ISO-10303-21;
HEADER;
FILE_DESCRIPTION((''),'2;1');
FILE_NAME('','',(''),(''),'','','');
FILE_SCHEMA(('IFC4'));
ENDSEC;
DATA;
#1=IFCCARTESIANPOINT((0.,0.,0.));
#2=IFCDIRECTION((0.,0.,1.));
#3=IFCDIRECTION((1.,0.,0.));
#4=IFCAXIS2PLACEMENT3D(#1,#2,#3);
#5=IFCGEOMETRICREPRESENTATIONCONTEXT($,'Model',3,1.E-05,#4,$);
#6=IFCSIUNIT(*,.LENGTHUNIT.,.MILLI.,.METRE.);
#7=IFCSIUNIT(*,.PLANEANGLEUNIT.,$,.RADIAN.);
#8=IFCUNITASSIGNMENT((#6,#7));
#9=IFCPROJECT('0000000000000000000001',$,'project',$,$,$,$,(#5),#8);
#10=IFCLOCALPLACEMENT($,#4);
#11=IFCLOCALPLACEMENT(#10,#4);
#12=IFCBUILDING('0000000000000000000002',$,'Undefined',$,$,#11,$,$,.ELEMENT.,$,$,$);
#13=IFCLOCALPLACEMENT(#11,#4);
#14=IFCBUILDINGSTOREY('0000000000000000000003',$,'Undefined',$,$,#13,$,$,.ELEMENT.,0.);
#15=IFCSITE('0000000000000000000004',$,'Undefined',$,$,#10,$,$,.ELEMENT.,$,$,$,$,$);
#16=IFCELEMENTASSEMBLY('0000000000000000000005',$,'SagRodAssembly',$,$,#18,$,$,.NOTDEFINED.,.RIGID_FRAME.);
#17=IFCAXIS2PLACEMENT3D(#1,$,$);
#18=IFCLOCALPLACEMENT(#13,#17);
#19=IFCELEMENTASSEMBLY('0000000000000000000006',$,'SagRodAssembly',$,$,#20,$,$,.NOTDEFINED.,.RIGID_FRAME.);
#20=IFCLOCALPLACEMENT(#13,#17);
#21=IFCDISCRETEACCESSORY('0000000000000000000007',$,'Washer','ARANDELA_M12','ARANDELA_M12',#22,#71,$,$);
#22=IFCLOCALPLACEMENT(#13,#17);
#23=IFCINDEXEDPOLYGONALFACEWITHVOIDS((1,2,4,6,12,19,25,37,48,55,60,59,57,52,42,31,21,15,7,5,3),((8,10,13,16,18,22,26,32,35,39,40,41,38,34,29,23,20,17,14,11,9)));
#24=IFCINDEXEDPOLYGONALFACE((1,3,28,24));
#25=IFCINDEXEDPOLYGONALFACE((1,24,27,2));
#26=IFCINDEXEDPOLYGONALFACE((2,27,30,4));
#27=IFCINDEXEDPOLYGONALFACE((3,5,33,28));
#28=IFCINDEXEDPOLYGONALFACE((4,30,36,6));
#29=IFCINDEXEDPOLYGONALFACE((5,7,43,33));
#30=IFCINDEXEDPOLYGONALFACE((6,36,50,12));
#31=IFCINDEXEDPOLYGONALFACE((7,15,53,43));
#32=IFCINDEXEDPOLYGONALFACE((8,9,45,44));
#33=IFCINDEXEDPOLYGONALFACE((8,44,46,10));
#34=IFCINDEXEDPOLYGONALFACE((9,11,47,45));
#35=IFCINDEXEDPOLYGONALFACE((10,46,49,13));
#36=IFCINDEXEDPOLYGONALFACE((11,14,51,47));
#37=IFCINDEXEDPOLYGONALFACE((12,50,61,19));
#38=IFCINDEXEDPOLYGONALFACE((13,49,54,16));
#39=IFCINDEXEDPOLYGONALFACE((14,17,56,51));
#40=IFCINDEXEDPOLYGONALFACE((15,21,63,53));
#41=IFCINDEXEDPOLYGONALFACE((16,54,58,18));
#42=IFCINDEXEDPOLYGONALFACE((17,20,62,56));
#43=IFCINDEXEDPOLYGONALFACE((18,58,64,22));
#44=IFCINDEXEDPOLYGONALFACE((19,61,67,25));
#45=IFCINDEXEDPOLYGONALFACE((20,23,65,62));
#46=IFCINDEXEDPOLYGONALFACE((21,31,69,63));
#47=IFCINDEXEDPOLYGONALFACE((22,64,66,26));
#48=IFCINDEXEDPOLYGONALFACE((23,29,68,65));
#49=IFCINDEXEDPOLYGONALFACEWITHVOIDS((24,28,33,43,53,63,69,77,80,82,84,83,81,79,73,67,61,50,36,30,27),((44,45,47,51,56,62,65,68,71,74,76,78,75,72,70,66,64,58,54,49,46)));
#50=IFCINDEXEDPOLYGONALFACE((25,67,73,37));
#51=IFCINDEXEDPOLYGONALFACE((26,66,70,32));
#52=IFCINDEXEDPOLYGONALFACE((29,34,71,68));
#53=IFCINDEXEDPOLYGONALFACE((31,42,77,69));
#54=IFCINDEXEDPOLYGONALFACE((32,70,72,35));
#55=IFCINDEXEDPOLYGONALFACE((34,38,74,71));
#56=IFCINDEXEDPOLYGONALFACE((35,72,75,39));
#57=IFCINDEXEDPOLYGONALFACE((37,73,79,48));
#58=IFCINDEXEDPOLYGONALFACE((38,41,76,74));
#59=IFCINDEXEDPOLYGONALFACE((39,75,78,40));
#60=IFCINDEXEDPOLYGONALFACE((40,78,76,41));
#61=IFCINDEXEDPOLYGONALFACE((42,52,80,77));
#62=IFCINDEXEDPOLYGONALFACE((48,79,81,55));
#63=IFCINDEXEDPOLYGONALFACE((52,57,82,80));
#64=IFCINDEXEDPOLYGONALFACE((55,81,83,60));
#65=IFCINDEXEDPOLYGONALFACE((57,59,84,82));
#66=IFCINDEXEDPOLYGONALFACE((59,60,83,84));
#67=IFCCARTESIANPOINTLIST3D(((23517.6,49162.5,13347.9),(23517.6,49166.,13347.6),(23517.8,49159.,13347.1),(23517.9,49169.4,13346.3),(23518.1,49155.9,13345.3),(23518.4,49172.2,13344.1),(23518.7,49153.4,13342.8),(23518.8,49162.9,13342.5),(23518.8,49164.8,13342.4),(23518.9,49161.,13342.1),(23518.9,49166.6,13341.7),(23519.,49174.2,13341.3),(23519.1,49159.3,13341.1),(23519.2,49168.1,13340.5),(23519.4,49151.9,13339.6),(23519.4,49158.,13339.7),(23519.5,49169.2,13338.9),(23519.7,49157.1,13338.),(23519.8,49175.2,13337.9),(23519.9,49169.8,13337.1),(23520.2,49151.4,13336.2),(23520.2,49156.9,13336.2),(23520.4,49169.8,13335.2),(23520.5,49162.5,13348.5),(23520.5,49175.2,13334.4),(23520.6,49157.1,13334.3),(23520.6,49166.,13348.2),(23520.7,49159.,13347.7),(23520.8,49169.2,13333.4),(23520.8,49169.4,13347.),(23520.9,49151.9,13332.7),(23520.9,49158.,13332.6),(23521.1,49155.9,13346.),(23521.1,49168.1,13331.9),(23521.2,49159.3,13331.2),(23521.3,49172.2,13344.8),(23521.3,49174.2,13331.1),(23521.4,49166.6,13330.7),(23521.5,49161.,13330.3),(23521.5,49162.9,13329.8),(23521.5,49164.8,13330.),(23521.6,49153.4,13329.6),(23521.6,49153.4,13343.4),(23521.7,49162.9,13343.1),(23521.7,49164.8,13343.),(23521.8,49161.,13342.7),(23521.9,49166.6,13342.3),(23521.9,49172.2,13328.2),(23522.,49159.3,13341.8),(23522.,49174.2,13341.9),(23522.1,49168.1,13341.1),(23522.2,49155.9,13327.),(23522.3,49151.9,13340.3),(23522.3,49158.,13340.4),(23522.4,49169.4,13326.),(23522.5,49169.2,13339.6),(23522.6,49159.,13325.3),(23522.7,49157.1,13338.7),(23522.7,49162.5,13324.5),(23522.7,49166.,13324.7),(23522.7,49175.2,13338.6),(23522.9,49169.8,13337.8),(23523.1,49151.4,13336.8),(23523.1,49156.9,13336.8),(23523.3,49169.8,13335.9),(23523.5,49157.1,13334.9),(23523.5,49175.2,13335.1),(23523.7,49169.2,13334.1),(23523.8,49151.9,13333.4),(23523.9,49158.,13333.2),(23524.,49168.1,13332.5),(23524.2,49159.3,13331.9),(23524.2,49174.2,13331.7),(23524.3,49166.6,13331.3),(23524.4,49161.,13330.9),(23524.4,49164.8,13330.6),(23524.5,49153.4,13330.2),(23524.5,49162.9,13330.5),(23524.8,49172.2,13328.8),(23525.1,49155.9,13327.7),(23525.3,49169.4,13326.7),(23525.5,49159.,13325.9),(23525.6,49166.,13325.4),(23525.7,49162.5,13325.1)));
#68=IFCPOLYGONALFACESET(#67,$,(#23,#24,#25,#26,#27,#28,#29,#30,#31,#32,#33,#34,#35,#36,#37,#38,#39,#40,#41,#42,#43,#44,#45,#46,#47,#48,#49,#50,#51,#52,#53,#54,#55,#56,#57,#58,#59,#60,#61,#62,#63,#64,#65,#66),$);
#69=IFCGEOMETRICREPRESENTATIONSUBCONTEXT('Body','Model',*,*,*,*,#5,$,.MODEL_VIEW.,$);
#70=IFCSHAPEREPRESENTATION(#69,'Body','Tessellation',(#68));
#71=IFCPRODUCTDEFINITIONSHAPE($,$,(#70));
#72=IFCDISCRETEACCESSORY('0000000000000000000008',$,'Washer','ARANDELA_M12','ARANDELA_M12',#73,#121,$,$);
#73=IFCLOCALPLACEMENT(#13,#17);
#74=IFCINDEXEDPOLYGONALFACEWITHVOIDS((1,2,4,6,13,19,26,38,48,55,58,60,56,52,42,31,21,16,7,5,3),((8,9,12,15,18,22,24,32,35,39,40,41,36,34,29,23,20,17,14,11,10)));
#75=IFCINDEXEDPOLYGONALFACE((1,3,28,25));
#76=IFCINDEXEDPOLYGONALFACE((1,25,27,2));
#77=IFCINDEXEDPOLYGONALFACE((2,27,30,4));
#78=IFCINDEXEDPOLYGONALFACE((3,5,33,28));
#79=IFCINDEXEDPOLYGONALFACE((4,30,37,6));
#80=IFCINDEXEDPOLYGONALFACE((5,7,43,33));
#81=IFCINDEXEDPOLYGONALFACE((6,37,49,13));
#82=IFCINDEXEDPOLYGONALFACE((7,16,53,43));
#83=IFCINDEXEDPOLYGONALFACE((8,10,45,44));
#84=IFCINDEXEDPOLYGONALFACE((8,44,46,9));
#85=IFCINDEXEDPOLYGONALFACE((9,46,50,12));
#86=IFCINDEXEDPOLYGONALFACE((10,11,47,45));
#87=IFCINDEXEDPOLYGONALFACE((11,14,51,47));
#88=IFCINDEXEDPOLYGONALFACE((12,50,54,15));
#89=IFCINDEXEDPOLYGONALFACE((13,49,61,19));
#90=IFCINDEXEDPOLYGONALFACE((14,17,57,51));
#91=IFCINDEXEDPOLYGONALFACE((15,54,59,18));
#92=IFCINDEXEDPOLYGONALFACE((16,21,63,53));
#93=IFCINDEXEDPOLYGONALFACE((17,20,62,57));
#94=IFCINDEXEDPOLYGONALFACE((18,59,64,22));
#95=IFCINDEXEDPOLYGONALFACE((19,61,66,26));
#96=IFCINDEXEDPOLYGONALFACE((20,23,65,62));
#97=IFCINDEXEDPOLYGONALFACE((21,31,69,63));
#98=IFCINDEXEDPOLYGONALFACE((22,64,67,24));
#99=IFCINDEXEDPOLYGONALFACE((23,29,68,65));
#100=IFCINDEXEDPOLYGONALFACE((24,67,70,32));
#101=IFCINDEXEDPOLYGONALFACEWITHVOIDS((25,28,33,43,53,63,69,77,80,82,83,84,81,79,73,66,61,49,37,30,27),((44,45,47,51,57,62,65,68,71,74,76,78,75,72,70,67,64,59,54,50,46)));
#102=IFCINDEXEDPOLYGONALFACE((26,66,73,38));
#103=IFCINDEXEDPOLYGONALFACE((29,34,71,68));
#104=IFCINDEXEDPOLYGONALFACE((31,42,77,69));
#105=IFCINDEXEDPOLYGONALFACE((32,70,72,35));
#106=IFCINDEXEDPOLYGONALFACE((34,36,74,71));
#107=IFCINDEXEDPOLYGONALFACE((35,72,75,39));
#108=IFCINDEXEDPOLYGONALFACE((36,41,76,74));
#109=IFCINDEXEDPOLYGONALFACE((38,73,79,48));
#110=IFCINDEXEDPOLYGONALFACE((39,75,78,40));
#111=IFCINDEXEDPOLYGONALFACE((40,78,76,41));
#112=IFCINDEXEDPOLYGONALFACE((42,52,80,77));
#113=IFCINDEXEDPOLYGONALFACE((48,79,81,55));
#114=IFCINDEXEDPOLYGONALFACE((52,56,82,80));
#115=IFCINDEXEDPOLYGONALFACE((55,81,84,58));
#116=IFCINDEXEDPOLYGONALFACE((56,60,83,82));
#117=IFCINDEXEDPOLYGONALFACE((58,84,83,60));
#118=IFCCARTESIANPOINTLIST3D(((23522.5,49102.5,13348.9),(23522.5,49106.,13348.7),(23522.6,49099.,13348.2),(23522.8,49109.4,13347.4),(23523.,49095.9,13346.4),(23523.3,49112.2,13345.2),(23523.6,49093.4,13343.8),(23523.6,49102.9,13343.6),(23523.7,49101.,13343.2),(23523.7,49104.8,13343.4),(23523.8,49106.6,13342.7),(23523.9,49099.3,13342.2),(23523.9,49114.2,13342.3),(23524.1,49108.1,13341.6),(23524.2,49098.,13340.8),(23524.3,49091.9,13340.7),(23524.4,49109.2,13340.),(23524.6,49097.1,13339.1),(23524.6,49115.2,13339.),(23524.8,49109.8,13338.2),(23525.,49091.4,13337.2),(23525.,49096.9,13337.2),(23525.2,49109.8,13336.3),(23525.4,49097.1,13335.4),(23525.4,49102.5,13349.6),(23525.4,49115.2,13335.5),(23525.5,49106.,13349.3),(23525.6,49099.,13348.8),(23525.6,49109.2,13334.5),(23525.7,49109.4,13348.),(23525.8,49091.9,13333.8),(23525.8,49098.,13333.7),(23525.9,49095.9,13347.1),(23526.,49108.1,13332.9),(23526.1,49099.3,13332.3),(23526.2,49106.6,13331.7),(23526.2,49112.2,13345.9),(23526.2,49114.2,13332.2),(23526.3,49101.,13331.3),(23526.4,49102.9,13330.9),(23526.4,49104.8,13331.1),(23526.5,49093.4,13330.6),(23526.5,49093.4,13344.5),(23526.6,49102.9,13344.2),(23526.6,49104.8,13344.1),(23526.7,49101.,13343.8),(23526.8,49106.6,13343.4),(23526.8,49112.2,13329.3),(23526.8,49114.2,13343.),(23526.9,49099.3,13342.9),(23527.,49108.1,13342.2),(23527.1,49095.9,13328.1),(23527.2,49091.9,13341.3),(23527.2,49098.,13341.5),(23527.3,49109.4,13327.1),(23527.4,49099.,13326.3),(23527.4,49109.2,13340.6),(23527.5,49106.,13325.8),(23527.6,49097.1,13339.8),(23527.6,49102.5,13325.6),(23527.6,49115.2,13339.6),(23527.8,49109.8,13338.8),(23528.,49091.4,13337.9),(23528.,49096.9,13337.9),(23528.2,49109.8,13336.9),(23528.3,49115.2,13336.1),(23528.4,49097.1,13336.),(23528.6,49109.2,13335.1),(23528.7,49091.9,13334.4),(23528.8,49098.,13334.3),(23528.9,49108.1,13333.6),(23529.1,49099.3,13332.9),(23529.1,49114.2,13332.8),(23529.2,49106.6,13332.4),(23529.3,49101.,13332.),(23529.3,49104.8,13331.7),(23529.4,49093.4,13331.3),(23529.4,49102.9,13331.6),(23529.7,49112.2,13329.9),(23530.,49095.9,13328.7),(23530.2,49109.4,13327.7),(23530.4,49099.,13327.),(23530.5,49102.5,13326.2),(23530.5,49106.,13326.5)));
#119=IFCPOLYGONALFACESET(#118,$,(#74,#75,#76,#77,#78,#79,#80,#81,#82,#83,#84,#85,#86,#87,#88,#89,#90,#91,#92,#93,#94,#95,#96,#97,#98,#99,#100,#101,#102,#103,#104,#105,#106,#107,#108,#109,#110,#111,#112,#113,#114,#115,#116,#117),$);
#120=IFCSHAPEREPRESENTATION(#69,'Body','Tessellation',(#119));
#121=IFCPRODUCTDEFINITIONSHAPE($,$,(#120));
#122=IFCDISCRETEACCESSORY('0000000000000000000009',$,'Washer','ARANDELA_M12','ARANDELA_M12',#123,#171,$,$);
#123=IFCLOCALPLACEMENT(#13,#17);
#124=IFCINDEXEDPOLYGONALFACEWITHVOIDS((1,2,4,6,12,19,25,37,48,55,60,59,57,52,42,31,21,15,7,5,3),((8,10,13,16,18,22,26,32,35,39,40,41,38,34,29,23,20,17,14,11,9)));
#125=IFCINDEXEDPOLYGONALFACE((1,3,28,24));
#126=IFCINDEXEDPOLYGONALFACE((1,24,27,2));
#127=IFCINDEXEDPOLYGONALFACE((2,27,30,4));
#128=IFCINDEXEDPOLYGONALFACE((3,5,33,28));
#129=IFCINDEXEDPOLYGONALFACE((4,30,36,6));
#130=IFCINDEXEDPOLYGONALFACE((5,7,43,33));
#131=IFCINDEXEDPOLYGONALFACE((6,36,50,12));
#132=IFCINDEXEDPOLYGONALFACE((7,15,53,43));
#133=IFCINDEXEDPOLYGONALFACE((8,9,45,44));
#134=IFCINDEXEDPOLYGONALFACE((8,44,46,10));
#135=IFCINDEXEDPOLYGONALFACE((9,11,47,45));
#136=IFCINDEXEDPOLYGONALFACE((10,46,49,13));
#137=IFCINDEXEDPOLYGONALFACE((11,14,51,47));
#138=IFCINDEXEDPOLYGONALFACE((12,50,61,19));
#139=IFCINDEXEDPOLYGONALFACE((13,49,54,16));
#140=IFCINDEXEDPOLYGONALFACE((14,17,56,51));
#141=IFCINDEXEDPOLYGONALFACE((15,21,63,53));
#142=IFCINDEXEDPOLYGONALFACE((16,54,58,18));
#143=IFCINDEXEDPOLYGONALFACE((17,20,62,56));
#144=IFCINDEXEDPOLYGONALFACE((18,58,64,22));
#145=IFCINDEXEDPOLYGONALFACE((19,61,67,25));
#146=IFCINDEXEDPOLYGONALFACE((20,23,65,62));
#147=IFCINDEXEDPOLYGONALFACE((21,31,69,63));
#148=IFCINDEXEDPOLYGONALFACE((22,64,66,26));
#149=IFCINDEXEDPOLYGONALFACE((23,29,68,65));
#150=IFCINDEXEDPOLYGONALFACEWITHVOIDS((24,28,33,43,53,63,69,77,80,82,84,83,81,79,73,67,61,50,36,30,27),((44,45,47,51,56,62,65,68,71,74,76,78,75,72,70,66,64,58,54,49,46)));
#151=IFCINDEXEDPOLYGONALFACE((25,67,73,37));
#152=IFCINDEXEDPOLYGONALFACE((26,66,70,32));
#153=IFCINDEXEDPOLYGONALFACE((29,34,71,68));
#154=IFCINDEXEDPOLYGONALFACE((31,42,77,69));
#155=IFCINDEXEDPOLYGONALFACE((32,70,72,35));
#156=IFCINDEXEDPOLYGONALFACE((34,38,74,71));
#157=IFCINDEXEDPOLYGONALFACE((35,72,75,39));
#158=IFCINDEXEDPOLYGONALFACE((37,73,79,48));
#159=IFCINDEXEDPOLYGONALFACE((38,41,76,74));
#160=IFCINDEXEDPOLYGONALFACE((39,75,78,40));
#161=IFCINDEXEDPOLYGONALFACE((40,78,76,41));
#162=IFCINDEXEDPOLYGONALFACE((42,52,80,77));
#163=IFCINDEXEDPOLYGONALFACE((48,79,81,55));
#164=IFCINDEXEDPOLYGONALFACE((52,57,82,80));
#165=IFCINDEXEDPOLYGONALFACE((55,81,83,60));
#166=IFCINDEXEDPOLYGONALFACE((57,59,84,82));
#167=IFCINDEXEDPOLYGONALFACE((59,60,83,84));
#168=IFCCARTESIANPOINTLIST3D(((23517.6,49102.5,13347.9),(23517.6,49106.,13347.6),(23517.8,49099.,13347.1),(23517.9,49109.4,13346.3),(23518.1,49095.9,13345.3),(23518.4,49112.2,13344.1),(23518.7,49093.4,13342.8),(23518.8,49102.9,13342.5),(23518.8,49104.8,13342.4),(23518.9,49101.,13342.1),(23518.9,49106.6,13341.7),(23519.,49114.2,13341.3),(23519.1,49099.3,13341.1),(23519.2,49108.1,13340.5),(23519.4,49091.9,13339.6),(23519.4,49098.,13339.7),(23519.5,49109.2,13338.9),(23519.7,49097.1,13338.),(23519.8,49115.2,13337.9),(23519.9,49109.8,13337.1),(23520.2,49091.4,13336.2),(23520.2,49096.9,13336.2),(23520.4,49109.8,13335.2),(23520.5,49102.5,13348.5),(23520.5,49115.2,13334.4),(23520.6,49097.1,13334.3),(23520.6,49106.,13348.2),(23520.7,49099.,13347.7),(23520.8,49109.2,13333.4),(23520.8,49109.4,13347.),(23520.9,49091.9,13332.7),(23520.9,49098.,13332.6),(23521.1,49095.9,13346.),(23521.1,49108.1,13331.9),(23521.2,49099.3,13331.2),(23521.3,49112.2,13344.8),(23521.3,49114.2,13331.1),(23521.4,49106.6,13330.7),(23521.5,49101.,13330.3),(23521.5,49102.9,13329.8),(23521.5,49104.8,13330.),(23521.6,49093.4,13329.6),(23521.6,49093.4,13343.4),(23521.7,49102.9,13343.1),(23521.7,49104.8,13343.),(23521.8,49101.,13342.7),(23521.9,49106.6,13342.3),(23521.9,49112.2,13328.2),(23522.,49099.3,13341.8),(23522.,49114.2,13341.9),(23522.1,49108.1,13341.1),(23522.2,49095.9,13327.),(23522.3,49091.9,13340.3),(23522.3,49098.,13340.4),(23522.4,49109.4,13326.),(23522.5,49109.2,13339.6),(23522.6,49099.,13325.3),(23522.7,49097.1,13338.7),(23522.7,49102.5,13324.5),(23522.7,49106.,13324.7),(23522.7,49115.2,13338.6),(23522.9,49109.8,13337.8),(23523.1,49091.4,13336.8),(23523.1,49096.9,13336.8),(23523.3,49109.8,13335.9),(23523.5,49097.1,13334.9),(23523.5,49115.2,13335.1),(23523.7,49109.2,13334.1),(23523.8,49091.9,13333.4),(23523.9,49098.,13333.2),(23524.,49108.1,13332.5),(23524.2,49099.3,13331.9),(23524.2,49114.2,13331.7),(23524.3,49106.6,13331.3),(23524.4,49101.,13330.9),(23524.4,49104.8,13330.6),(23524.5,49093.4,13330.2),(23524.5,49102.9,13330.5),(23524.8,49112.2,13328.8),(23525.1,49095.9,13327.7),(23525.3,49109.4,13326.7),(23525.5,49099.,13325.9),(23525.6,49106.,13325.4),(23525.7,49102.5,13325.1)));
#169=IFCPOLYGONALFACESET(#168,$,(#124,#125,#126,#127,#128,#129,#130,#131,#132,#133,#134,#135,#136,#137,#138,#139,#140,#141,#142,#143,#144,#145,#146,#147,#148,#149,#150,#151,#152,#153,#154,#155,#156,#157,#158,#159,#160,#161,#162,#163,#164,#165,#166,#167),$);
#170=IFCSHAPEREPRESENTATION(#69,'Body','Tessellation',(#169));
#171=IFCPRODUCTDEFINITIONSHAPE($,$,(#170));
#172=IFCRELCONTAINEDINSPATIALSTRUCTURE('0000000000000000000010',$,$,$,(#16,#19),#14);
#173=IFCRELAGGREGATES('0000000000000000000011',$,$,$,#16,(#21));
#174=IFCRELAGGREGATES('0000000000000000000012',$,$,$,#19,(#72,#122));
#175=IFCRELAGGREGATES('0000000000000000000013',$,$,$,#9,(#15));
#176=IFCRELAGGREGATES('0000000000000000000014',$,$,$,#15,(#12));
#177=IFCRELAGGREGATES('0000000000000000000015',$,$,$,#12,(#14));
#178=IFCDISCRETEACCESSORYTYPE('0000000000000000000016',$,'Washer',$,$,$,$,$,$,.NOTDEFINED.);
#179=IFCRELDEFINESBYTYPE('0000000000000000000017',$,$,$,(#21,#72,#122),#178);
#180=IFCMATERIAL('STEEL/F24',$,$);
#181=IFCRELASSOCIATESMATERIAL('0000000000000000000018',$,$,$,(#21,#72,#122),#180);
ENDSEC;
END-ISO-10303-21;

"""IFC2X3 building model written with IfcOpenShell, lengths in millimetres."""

from ifc_helpers import new_model, si_unit, frame, origin_with_axes, origin_2d_with_axis, place, context, subcontext, project, spatial, hollow_circle, extrude, material, type_object, element, aggregate, save


model = new_model("IFC2X3")

# Units and contexts
model_context = context("Model", 3, precision=1e-05, world=origin_with_axes())
body_context = subcontext(model_context, "Body", "Model", "MODEL_VIEW")
ifc_project = project(units=[si_unit("LENGTHUNIT", "METRE", prefix="MILLI"), si_unit("PLANEANGLEUNIT", "RADIAN")], contexts=[model_context])

# Site, building, storey
site_placement = place(None, origin_with_axes())
site = spatial("IfcSite", under=ifc_project, at=site_placement, Name="Undefined", CompositionType="ELEMENT")
building_placement = place(site_placement, origin_with_axes())
building = spatial("IfcBuilding", under=site, at=building_placement, Name="Undefined", CompositionType="ELEMENT")
storey_placement = place(building_placement, origin_with_axes())
storey = spatial("IfcBuildingStorey", under=building, at=storey_placement, Name="Undefined", CompositionType="ELEMENT", Elevation=0.0)

# Element assemblies
assembly_1_placement = place(storey_placement, origin_with_axes())
assembly_1 = element("IfcElementAssembly", 1, at=assembly_1_placement, inside=storey, Name="SagRodAssembly", AssemblyPlace="NOTDEFINED", PredefinedType="RIGID_FRAME")
ifc_material = material(Name="STEEL/F24")
assembly_2_placement = place(storey_placement, origin_with_axes())
assembly_2 = element("IfcElementAssembly", 2, at=assembly_2_placement, inside=storey, Name="SagRodAssembly", AssemblyPlace="NOTDEFINED", PredefinedType="RIGID_FRAME")

# Discrete accessories
discrete_accessory_type_1 = type_object("IfcDiscreteAccessoryType", Name="Washer")
discrete_accessory_1_placement = place(assembly_1_placement, frame((23520.2, 49163.4, 13336.2), z_axis=(-0.214887, 0.0, 0.976639), x_axis=(0.976639, 0.0, 0.214887)))
discrete_accessory_1 = element("IfcDiscreteAccessory", 3, at=discrete_accessory_1_placement, type_object=discrete_accessory_type_1, material=ifc_material, Name="Washer", Description="ARANDELA_M12", ObjectType="ARANDELA_M12", context=body_context, shape_type="SweptSolid", body=[
    extrude(hollow_circle(Radius=12.0, WallThickness=5.5, at=origin_2d_with_axis()), frame((3.0, 0.0, 0.0), z_axis=(-1.0, 0.0, 0.0), x_axis=(0.0, -1.0, 0.0)), (0.0, 0.0, 1.0), 3.0),
])
aggregate(assembly_1, [discrete_accessory_1])
discrete_accessory_2_placement = place(assembly_2_placement, frame((23525.0, 49103.4, 13337.2), z_axis=(-0.214887, 0.0, 0.976639), x_axis=(0.976639, 0.0, 0.214887)))
discrete_accessory_2 = element("IfcDiscreteAccessory", 4, at=discrete_accessory_2_placement, type_object=discrete_accessory_type_1, material=ifc_material, Name="Washer", Description="ARANDELA_M12", ObjectType="ARANDELA_M12", context=body_context, shape_type="SweptSolid", body=[
    extrude(hollow_circle(Radius=12.0, WallThickness=5.5, at=origin_2d_with_axis()), frame((3.0, 0.0, 0.0), z_axis=(-1.0, 0.0, 0.0), x_axis=(0.0, -1.0, 0.0)), (0.0, 0.0, 1.0), 3.0),
])
discrete_accessory_3_placement = place(assembly_2_placement, frame((23520.2, 49103.4, 13336.2), z_axis=(-0.214887, 0.0, 0.976639), x_axis=(0.976639, 0.0, 0.214887)))
discrete_accessory_3 = element("IfcDiscreteAccessory", 5, at=discrete_accessory_3_placement, type_object=discrete_accessory_type_1, material=ifc_material, Name="Washer", Description="ARANDELA_M12", ObjectType="ARANDELA_M12", context=body_context, shape_type="SweptSolid", body=[
    extrude(hollow_circle(Radius=12.0, WallThickness=5.5, at=origin_2d_with_axis()), frame((3.0, 0.0, 0.0), z_axis=(-1.0, 0.0, 0.0), x_axis=(0.0, -1.0, 0.0)), (0.0, 0.0, 1.0), 3.0),
])
aggregate(assembly_2, [discrete_accessory_2, discrete_accessory_3])

save(model, "model.ifc")
